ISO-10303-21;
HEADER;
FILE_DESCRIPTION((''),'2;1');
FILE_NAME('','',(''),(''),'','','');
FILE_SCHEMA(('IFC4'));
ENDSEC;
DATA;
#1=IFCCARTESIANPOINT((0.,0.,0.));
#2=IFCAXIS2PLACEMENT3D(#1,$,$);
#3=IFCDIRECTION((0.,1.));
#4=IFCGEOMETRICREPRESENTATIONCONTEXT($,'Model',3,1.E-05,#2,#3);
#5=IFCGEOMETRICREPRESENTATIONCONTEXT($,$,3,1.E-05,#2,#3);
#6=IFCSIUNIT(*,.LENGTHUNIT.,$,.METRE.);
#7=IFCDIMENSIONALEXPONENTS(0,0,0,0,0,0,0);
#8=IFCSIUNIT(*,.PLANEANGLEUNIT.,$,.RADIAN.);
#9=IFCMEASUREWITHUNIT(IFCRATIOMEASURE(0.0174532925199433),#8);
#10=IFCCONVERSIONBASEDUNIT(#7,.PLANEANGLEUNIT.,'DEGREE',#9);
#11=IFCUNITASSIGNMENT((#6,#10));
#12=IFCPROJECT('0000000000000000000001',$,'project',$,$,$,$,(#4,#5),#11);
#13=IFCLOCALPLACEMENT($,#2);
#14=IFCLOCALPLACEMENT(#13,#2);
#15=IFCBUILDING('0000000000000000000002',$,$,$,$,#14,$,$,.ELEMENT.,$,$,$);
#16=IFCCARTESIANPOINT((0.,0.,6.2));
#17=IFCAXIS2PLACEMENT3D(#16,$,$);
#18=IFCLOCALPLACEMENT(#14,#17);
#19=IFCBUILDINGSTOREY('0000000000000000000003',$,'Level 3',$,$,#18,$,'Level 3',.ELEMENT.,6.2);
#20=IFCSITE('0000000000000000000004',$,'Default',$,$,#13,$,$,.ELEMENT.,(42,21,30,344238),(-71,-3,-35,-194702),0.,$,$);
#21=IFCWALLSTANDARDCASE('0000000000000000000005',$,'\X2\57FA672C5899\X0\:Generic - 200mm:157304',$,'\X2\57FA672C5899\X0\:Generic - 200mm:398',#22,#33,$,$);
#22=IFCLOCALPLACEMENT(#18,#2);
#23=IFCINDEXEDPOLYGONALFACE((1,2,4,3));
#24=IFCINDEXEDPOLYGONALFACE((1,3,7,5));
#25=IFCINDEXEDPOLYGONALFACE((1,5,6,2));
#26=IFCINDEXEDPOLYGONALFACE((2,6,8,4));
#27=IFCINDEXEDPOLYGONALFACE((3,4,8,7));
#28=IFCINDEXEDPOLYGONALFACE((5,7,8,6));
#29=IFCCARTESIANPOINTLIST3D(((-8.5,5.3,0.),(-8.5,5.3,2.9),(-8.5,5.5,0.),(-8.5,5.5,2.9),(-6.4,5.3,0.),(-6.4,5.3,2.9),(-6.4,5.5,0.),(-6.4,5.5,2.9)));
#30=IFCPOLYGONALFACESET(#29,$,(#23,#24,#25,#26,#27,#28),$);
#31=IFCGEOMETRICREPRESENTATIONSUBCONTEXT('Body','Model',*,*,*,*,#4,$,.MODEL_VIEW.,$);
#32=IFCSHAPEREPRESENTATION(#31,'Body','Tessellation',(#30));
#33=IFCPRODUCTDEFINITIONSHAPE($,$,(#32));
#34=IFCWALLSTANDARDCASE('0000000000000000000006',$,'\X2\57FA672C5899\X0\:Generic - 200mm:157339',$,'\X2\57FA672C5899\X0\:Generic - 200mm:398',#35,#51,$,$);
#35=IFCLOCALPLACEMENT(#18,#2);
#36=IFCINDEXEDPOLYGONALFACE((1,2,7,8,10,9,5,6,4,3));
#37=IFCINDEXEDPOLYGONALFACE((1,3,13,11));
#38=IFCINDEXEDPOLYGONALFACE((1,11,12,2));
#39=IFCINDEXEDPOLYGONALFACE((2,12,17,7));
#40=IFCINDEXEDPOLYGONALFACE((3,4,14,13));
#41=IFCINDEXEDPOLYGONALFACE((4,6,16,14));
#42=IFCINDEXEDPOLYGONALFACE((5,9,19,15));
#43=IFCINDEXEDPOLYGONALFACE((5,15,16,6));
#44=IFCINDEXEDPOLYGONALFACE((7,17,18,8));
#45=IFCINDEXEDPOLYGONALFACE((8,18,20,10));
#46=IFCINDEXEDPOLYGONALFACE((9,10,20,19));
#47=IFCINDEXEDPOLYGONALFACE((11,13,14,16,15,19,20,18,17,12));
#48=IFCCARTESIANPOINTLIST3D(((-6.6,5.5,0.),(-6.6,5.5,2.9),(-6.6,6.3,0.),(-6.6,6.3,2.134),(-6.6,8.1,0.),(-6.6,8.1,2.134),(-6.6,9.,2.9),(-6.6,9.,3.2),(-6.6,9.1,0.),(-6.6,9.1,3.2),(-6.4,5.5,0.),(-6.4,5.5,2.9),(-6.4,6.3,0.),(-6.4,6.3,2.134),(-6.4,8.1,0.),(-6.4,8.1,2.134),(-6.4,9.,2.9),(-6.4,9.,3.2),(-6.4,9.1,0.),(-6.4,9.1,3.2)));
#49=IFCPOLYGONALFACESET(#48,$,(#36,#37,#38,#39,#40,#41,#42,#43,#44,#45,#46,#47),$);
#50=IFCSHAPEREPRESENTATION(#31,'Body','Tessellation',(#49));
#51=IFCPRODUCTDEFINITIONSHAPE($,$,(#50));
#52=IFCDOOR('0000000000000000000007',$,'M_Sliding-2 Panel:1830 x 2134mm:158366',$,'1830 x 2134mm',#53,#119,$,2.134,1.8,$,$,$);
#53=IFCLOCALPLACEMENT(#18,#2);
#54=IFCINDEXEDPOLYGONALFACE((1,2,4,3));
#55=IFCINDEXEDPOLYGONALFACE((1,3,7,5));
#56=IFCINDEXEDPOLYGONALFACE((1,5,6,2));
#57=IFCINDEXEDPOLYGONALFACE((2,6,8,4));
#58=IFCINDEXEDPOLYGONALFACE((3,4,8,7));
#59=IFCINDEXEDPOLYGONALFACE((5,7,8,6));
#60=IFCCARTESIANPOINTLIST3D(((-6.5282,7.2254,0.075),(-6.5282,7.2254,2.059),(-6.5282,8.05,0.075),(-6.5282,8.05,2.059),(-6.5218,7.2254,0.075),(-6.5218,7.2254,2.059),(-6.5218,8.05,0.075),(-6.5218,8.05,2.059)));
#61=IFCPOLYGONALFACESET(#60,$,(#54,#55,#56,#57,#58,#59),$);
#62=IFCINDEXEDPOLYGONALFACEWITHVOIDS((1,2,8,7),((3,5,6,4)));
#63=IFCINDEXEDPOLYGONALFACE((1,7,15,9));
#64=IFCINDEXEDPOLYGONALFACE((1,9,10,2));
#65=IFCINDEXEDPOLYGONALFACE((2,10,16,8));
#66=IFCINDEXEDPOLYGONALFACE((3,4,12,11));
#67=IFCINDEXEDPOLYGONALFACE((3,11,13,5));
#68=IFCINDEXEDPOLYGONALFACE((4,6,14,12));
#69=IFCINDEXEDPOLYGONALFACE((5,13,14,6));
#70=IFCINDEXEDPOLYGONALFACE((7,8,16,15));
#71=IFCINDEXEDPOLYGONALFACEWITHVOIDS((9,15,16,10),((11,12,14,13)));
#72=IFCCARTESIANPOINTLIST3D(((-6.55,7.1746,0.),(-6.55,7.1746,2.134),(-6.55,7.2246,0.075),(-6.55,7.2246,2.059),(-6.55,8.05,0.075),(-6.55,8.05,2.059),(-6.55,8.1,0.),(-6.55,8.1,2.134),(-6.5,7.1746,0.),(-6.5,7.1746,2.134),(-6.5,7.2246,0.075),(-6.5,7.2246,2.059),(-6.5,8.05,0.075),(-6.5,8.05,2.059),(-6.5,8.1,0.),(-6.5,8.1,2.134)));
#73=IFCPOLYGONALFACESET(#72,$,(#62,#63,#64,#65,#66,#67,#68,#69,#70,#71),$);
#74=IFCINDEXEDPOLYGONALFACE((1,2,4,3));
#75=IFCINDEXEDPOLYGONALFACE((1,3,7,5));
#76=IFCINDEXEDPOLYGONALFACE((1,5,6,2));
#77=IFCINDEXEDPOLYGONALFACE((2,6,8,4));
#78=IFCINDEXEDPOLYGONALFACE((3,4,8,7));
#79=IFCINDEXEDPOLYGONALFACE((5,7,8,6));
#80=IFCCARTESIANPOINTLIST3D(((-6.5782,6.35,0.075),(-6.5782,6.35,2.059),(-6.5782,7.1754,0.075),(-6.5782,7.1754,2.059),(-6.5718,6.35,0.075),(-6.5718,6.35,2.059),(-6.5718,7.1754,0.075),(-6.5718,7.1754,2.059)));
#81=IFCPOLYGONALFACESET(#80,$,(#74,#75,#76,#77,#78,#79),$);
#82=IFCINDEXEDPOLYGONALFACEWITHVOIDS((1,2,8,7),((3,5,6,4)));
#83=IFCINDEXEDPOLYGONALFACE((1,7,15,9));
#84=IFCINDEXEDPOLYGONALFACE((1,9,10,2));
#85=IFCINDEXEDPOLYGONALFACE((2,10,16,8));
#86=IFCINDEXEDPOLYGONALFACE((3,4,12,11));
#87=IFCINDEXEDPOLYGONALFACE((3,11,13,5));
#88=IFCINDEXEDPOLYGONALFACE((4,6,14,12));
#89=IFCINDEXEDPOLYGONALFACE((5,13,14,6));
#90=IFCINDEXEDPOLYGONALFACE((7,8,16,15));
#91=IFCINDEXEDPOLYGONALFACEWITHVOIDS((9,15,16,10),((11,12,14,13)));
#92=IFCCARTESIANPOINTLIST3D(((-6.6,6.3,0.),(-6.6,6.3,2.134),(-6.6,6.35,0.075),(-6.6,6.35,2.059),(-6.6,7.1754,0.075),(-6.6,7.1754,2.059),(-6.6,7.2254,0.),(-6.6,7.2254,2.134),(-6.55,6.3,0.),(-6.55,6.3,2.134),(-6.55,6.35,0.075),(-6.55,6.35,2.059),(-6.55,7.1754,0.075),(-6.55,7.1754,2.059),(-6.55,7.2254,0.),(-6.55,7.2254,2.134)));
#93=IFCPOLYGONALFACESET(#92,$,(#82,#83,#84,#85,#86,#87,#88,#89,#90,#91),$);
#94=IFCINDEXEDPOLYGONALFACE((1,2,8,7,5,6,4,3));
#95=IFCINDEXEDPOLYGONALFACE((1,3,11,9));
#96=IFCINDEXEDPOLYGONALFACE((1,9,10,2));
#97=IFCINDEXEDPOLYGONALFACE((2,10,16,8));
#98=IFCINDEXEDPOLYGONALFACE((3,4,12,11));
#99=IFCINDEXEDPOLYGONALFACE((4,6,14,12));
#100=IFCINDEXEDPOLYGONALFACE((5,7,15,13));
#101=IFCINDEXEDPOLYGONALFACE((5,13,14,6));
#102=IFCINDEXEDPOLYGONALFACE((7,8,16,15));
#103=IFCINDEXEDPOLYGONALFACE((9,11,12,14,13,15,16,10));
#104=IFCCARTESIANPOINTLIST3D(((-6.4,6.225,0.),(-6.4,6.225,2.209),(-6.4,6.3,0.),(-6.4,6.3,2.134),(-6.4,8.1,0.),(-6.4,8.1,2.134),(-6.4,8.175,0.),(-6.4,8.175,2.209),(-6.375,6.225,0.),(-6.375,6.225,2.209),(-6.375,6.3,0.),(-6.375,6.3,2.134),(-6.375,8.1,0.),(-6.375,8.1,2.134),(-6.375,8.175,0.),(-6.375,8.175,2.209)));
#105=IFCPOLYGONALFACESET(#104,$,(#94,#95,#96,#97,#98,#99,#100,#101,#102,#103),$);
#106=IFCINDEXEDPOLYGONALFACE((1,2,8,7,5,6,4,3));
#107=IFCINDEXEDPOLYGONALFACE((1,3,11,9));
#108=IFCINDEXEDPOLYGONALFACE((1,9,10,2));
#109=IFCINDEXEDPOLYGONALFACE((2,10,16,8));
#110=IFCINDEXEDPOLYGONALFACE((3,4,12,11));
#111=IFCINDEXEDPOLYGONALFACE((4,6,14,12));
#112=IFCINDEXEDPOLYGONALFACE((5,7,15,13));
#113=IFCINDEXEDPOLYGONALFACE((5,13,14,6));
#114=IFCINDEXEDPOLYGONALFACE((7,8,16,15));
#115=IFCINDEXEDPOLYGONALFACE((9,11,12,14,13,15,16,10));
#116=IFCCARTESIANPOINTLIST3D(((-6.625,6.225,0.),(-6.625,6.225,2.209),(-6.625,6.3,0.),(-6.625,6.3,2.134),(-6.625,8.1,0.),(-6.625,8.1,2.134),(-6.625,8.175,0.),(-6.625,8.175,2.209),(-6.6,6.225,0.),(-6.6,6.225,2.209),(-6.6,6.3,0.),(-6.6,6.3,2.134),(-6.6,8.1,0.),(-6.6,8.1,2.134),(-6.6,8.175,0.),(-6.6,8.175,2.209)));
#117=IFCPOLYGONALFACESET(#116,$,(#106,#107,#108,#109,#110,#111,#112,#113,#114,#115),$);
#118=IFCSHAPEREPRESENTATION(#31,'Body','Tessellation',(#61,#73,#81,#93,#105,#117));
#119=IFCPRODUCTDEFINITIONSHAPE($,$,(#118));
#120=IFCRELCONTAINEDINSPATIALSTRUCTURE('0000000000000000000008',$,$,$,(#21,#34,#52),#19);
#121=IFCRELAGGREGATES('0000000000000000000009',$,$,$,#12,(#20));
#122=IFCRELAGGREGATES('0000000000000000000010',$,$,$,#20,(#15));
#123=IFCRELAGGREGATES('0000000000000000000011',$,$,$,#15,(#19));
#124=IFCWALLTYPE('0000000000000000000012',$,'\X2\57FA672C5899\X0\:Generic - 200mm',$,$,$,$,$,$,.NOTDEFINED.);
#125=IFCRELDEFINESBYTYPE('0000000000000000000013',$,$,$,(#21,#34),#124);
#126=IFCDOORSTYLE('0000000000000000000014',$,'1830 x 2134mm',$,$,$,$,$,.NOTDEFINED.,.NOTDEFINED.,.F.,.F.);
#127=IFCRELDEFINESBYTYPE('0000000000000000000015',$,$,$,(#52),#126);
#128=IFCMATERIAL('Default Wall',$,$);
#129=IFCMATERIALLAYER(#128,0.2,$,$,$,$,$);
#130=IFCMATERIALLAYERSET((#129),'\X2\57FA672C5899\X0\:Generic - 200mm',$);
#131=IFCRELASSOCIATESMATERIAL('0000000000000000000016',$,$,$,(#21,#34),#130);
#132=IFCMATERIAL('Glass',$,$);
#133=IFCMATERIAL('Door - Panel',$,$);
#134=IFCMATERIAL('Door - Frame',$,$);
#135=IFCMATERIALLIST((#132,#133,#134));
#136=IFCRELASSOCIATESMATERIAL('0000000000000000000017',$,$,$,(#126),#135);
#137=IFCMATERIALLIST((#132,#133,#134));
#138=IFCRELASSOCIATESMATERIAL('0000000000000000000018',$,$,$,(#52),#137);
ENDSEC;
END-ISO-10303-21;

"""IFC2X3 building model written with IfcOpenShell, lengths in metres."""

from ifc_helpers import new_model, entity, si_unit, converted_unit, direction, frame, frame_2d, origin, place, context, subcontext, project, spatial, polyline, rectangle, outline, extrude, clip, bounded_halfspace, source, transform, mapped, material, material_list, layer, layer_set, layer_usage, type_object, type_shapes, element, fill, save


model = new_model("IFC2X3")

# Units and contexts
model_context = context("Model", 3, precision=1e-05, world=origin(), true_north=direction((0.0, 1.0)))
context_of_model = context(None, 3, precision=1e-05, world=origin(), true_north=direction((0.0, 1.0)))
body_context = subcontext(model_context, "Body", "Model", "MODEL_VIEW")
ifc_project = project(units=[si_unit("LENGTHUNIT", "METRE"), converted_unit("PLANEANGLEUNIT", "DEGREE", entity("IfcRatioMeasure", 0.0174532925199433), si_unit("PLANEANGLEUNIT", "RADIAN"), dimensions=[0, 0, 0, 0, 0, 0, 0])], contexts=[model_context, context_of_model])

# Site, building, storey
site_placement = place(None, origin())
site = spatial("IfcSite", under=ifc_project, at=site_placement, Name="Default", CompositionType="ELEMENT", RefLatitude=(42, 21, 30, 344238), RefLongitude=(-71, -3, -35, -194702), RefElevation=0.0)
building_placement = place(site_placement, origin())
building = spatial("IfcBuilding", under=site, at=building_placement, CompositionType="ELEMENT")
storey_placement = place(building_placement, frame((0.0, 0.0, 6.2)))
storey = spatial("IfcBuildingStorey", under=building, at=storey_placement, Name="Level 3", LongName="Level 3", CompositionType="ELEMENT", Elevation=6.2)

# Wall
ifc_material_1 = material(Name="Default Wall")
ifc_layer_1 = layer(ifc_material_1, 0.2)
ifc_layer_set_1 = layer_set([ifc_layer_1], Name="基本墙:Generic - 200mm")
ifc_layer_usage_1 = layer_usage(ifc_layer_set_1, "AXIS2", "NEGATIVE", 0.1)
wall_type_1 = type_object("IfcWallType", Name="基本墙:Generic - 200mm", PredefinedType="NOTDEFINED")
wall_1_placement = place(storey_placement, frame((-8.5, 5.4, 0.0)))
element("IfcWallStandardCase", 1, at=wall_1_placement, inside=storey, type_object=wall_type_1, material=ifc_layer_usage_1, Name="基本墙:Generic - 200mm:157304", ObjectType="基本墙:Generic - 200mm:398", context=body_context, shape_type="Clipping", body=[
    clip(extrude(rectangle(XDim=2.1, YDim=0.2, at=frame_2d((1.05, 0.0), x_axis=(-1.0, 0.0))), origin(), (0.0, 0.0, 1.0), 3.2), bounded_halfspace(frame((0.0, -0.1, 2.9), z_axis=(0.0, 0.0, -1.0), x_axis=(0.0, -1.0, 0.0)), True, frame((0.0, -0.1, 2.9), z_axis=(0.0, 0.0, -1.0), x_axis=(0.0, -1.0, 0.0)), polyline([(0.0, 0.0), (-0.2, 0.0), (-0.2, -1.9), (-0.2, -2.1), (-0.1, -2.1), (0.0, -2.1), (0.0, 0.0)]))),
])

# Wall, opening, door
ifc_layer_usage_2 = layer_usage(ifc_layer_set_1, "AXIS2", "NEGATIVE", 0.1)
wall_2_placement = place(storey_placement, frame((-6.5, 5.5, 0.0), z_axis=(0.0, 0.0, 1.0), x_axis=(0.0, 1.0, 0.0)))
wall_2 = element("IfcWallStandardCase", 2, at=wall_2_placement, inside=storey, type_object=wall_type_1, material=ifc_layer_usage_2, Name="基本墙:Generic - 200mm:157339", ObjectType="基本墙:Generic - 200mm:398", context=body_context, shape_type="Clipping", body=[
    clip(clip(extrude(rectangle(XDim=3.6, YDim=0.2, at=frame_2d((1.8, 0.0), x_axis=(-1.0, 0.0))), origin(), (0.0, 0.0, 1.0), 3.2), bounded_halfspace(frame((3.5, -0.1, 2.9), z_axis=(0.0, 0.0, -1.0), x_axis=(-1.0, 0.0, 0.0)), True, frame((3.5, -0.1, 2.9), z_axis=(0.0, 0.0, -1.0), x_axis=(-1.0, 0.0, 0.0)), polyline([(0.0, 0.0), (0.1, 0.0), (3.5, 0.0), (3.5, 0.2), (0.0, 0.2), (0.0, 0.0)]))), bounded_halfspace(frame((3.5, 0.1, 2.9), z_axis=(1.0, 0.0, 0.0), x_axis=(0.0, 0.0, 1.0)), True, frame((3.5, 0.1, 2.9), z_axis=(1.0, 0.0, 0.0), x_axis=(0.0, 0.0, 1.0)), polyline([(0.0, 0.0), (0.3, 0.0), (0.3, 0.2), (0.0, 0.2), (0.0, 0.0)]))),
])
opening_1_placement = place(wall_2_placement, frame((0.8, -0.1, 0.0)))
opening_1 = element("IfcOpeningElement", 3, at=opening_1_placement, cuts=wall_2, ObjectType="Opening", context=body_context, shape_type="SweptSolid", body=[
    extrude(rectangle(XDim=2.134, YDim=1.8, at=frame_2d((1.067, 0.9), x_axis=(-1.0, 0.0))), frame((0.0, 0.0, 0.0), z_axis=(0.0, 1.0, 0.0), x_axis=(0.0, 0.0, 1.0)), (0.0, 0.0, 1.0), 0.2),
])
ifc_material_2 = material(Name="Glass")
ifc_material_3 = material(Name="Door - Panel")
ifc_material_4 = material(Name="Door - Frame")
ifc_material_list_1 = material_list([ifc_material_2, ifc_material_3, ifc_material_4])
ifc_material_list_2 = material_list([ifc_material_2, ifc_material_3, ifc_material_4])
door_style_1 = type_object("IfcDoorStyle", Name="1830 x 2134mm", ConstructionType="NOTDEFINED", OperationType="NOTDEFINED", ParameterTakesPrecedence=False, Sizeable=False, material=ifc_material_list_2)
shared_shape_1 = source(origin(), body_context, "Body", "SweptSolid", [
    extrude(rectangle(XDim=0.0063, YDim=0.8246, at=frame_2d((0.0, 0.0), x_axis=(1.0, 0.0))), frame((1.3377, 0.125, 0.075), z_axis=(0.0, 0.0, 1.0), x_axis=(0.0, -1.0, 0.0)), (0.0, 0.0, 1.0), 1.984),
    extrude(outline(polyline([(-0.4627, -1.067), (0.4627, -1.067), (0.4627, 1.067), (-0.4627, 1.067), (-0.4627, -1.067)]), holes=[polyline([(-0.4127, -0.992), (-0.4127, 0.992), (0.4127, 0.992), (0.4127, -0.992), (-0.4127, -0.992)])]), frame((1.3373, 0.1, 1.067), z_axis=(0.0, 1.0, 0.0), x_axis=(1.0, 0.0, 0.0)), (0.0, 0.0, 1.0), 0.05),
    extrude(rectangle(XDim=0.0063, YDim=0.8254, at=frame_2d((0.0, 0.0), x_axis=(1.0, 0.0))), frame((0.4627, 0.175, 0.075), z_axis=(0.0, 0.0, 1.0), x_axis=(0.0, -1.0, 0.0)), (0.0, 0.0, 1.0), 1.984),
    extrude(outline(polyline([(-1.067, -0.4627), (1.067, -0.4627), (1.067, 0.4627), (-1.067, 0.4627), (-1.067, -0.4627)]), holes=[polyline([(-0.992, -0.4127), (-0.992, 0.4127), (0.992, 0.4127), (0.992, -0.4127), (-0.992, -0.4127)])]), frame((0.4627, 0.15, 1.067), z_axis=(0.0, 1.0, 0.0), x_axis=(0.0, 0.0, -1.0)), (0.0, 0.0, 1.0), 0.05),
    extrude(outline(polyline([(-1.0857, -0.975), (1.1233, -0.975), (1.1233, 0.975), (-1.0857, 0.975), (-1.0857, 0.9), (1.0482, 0.9), (1.0482, -0.9), (-1.0857, -0.9), (-1.0857, -0.975)])), frame((0.9, -0.025, 1.0857), z_axis=(0.0, 1.0, 0.0), x_axis=(0.0, 0.0, 1.0)), (0.0, 0.0, 1.0), 0.025),
    extrude(outline(polyline([(-0.975, -1.0857), (-0.9, -1.0857), (-0.9, 1.0482), (0.9, 1.0482), (0.9, -1.0857), (0.975, -1.0857), (0.975, 1.1233), (-0.975, 1.1233), (-0.975, -1.0857)])), frame((0.9, 0.2, 1.0857), z_axis=(0.0, 1.0, 0.0), x_axis=(-1.0, 0.0, 0.0)), (0.0, 0.0, 1.0), 0.025),
])
type_shapes(door_style_1, [shared_shape_1])
door_1_placement = place(opening_1_placement, origin())
door_1 = element("IfcDoor", 4, at=door_1_placement, inside=storey, type_object=door_style_1, material=ifc_material_list_1, Name="M_Sliding-2 Panel:1830 x 2134mm:158366", ObjectType="1830 x 2134mm", OverallHeight=2.134, OverallWidth=1.8, context=body_context, shape_type="MappedRepresentation", body=[
    mapped(shared_shape_1, transform((0.0, 0.0, 0.0), scale=1.0)),
])
fill(opening_1, door_1)

save(model, "model.ifc")
